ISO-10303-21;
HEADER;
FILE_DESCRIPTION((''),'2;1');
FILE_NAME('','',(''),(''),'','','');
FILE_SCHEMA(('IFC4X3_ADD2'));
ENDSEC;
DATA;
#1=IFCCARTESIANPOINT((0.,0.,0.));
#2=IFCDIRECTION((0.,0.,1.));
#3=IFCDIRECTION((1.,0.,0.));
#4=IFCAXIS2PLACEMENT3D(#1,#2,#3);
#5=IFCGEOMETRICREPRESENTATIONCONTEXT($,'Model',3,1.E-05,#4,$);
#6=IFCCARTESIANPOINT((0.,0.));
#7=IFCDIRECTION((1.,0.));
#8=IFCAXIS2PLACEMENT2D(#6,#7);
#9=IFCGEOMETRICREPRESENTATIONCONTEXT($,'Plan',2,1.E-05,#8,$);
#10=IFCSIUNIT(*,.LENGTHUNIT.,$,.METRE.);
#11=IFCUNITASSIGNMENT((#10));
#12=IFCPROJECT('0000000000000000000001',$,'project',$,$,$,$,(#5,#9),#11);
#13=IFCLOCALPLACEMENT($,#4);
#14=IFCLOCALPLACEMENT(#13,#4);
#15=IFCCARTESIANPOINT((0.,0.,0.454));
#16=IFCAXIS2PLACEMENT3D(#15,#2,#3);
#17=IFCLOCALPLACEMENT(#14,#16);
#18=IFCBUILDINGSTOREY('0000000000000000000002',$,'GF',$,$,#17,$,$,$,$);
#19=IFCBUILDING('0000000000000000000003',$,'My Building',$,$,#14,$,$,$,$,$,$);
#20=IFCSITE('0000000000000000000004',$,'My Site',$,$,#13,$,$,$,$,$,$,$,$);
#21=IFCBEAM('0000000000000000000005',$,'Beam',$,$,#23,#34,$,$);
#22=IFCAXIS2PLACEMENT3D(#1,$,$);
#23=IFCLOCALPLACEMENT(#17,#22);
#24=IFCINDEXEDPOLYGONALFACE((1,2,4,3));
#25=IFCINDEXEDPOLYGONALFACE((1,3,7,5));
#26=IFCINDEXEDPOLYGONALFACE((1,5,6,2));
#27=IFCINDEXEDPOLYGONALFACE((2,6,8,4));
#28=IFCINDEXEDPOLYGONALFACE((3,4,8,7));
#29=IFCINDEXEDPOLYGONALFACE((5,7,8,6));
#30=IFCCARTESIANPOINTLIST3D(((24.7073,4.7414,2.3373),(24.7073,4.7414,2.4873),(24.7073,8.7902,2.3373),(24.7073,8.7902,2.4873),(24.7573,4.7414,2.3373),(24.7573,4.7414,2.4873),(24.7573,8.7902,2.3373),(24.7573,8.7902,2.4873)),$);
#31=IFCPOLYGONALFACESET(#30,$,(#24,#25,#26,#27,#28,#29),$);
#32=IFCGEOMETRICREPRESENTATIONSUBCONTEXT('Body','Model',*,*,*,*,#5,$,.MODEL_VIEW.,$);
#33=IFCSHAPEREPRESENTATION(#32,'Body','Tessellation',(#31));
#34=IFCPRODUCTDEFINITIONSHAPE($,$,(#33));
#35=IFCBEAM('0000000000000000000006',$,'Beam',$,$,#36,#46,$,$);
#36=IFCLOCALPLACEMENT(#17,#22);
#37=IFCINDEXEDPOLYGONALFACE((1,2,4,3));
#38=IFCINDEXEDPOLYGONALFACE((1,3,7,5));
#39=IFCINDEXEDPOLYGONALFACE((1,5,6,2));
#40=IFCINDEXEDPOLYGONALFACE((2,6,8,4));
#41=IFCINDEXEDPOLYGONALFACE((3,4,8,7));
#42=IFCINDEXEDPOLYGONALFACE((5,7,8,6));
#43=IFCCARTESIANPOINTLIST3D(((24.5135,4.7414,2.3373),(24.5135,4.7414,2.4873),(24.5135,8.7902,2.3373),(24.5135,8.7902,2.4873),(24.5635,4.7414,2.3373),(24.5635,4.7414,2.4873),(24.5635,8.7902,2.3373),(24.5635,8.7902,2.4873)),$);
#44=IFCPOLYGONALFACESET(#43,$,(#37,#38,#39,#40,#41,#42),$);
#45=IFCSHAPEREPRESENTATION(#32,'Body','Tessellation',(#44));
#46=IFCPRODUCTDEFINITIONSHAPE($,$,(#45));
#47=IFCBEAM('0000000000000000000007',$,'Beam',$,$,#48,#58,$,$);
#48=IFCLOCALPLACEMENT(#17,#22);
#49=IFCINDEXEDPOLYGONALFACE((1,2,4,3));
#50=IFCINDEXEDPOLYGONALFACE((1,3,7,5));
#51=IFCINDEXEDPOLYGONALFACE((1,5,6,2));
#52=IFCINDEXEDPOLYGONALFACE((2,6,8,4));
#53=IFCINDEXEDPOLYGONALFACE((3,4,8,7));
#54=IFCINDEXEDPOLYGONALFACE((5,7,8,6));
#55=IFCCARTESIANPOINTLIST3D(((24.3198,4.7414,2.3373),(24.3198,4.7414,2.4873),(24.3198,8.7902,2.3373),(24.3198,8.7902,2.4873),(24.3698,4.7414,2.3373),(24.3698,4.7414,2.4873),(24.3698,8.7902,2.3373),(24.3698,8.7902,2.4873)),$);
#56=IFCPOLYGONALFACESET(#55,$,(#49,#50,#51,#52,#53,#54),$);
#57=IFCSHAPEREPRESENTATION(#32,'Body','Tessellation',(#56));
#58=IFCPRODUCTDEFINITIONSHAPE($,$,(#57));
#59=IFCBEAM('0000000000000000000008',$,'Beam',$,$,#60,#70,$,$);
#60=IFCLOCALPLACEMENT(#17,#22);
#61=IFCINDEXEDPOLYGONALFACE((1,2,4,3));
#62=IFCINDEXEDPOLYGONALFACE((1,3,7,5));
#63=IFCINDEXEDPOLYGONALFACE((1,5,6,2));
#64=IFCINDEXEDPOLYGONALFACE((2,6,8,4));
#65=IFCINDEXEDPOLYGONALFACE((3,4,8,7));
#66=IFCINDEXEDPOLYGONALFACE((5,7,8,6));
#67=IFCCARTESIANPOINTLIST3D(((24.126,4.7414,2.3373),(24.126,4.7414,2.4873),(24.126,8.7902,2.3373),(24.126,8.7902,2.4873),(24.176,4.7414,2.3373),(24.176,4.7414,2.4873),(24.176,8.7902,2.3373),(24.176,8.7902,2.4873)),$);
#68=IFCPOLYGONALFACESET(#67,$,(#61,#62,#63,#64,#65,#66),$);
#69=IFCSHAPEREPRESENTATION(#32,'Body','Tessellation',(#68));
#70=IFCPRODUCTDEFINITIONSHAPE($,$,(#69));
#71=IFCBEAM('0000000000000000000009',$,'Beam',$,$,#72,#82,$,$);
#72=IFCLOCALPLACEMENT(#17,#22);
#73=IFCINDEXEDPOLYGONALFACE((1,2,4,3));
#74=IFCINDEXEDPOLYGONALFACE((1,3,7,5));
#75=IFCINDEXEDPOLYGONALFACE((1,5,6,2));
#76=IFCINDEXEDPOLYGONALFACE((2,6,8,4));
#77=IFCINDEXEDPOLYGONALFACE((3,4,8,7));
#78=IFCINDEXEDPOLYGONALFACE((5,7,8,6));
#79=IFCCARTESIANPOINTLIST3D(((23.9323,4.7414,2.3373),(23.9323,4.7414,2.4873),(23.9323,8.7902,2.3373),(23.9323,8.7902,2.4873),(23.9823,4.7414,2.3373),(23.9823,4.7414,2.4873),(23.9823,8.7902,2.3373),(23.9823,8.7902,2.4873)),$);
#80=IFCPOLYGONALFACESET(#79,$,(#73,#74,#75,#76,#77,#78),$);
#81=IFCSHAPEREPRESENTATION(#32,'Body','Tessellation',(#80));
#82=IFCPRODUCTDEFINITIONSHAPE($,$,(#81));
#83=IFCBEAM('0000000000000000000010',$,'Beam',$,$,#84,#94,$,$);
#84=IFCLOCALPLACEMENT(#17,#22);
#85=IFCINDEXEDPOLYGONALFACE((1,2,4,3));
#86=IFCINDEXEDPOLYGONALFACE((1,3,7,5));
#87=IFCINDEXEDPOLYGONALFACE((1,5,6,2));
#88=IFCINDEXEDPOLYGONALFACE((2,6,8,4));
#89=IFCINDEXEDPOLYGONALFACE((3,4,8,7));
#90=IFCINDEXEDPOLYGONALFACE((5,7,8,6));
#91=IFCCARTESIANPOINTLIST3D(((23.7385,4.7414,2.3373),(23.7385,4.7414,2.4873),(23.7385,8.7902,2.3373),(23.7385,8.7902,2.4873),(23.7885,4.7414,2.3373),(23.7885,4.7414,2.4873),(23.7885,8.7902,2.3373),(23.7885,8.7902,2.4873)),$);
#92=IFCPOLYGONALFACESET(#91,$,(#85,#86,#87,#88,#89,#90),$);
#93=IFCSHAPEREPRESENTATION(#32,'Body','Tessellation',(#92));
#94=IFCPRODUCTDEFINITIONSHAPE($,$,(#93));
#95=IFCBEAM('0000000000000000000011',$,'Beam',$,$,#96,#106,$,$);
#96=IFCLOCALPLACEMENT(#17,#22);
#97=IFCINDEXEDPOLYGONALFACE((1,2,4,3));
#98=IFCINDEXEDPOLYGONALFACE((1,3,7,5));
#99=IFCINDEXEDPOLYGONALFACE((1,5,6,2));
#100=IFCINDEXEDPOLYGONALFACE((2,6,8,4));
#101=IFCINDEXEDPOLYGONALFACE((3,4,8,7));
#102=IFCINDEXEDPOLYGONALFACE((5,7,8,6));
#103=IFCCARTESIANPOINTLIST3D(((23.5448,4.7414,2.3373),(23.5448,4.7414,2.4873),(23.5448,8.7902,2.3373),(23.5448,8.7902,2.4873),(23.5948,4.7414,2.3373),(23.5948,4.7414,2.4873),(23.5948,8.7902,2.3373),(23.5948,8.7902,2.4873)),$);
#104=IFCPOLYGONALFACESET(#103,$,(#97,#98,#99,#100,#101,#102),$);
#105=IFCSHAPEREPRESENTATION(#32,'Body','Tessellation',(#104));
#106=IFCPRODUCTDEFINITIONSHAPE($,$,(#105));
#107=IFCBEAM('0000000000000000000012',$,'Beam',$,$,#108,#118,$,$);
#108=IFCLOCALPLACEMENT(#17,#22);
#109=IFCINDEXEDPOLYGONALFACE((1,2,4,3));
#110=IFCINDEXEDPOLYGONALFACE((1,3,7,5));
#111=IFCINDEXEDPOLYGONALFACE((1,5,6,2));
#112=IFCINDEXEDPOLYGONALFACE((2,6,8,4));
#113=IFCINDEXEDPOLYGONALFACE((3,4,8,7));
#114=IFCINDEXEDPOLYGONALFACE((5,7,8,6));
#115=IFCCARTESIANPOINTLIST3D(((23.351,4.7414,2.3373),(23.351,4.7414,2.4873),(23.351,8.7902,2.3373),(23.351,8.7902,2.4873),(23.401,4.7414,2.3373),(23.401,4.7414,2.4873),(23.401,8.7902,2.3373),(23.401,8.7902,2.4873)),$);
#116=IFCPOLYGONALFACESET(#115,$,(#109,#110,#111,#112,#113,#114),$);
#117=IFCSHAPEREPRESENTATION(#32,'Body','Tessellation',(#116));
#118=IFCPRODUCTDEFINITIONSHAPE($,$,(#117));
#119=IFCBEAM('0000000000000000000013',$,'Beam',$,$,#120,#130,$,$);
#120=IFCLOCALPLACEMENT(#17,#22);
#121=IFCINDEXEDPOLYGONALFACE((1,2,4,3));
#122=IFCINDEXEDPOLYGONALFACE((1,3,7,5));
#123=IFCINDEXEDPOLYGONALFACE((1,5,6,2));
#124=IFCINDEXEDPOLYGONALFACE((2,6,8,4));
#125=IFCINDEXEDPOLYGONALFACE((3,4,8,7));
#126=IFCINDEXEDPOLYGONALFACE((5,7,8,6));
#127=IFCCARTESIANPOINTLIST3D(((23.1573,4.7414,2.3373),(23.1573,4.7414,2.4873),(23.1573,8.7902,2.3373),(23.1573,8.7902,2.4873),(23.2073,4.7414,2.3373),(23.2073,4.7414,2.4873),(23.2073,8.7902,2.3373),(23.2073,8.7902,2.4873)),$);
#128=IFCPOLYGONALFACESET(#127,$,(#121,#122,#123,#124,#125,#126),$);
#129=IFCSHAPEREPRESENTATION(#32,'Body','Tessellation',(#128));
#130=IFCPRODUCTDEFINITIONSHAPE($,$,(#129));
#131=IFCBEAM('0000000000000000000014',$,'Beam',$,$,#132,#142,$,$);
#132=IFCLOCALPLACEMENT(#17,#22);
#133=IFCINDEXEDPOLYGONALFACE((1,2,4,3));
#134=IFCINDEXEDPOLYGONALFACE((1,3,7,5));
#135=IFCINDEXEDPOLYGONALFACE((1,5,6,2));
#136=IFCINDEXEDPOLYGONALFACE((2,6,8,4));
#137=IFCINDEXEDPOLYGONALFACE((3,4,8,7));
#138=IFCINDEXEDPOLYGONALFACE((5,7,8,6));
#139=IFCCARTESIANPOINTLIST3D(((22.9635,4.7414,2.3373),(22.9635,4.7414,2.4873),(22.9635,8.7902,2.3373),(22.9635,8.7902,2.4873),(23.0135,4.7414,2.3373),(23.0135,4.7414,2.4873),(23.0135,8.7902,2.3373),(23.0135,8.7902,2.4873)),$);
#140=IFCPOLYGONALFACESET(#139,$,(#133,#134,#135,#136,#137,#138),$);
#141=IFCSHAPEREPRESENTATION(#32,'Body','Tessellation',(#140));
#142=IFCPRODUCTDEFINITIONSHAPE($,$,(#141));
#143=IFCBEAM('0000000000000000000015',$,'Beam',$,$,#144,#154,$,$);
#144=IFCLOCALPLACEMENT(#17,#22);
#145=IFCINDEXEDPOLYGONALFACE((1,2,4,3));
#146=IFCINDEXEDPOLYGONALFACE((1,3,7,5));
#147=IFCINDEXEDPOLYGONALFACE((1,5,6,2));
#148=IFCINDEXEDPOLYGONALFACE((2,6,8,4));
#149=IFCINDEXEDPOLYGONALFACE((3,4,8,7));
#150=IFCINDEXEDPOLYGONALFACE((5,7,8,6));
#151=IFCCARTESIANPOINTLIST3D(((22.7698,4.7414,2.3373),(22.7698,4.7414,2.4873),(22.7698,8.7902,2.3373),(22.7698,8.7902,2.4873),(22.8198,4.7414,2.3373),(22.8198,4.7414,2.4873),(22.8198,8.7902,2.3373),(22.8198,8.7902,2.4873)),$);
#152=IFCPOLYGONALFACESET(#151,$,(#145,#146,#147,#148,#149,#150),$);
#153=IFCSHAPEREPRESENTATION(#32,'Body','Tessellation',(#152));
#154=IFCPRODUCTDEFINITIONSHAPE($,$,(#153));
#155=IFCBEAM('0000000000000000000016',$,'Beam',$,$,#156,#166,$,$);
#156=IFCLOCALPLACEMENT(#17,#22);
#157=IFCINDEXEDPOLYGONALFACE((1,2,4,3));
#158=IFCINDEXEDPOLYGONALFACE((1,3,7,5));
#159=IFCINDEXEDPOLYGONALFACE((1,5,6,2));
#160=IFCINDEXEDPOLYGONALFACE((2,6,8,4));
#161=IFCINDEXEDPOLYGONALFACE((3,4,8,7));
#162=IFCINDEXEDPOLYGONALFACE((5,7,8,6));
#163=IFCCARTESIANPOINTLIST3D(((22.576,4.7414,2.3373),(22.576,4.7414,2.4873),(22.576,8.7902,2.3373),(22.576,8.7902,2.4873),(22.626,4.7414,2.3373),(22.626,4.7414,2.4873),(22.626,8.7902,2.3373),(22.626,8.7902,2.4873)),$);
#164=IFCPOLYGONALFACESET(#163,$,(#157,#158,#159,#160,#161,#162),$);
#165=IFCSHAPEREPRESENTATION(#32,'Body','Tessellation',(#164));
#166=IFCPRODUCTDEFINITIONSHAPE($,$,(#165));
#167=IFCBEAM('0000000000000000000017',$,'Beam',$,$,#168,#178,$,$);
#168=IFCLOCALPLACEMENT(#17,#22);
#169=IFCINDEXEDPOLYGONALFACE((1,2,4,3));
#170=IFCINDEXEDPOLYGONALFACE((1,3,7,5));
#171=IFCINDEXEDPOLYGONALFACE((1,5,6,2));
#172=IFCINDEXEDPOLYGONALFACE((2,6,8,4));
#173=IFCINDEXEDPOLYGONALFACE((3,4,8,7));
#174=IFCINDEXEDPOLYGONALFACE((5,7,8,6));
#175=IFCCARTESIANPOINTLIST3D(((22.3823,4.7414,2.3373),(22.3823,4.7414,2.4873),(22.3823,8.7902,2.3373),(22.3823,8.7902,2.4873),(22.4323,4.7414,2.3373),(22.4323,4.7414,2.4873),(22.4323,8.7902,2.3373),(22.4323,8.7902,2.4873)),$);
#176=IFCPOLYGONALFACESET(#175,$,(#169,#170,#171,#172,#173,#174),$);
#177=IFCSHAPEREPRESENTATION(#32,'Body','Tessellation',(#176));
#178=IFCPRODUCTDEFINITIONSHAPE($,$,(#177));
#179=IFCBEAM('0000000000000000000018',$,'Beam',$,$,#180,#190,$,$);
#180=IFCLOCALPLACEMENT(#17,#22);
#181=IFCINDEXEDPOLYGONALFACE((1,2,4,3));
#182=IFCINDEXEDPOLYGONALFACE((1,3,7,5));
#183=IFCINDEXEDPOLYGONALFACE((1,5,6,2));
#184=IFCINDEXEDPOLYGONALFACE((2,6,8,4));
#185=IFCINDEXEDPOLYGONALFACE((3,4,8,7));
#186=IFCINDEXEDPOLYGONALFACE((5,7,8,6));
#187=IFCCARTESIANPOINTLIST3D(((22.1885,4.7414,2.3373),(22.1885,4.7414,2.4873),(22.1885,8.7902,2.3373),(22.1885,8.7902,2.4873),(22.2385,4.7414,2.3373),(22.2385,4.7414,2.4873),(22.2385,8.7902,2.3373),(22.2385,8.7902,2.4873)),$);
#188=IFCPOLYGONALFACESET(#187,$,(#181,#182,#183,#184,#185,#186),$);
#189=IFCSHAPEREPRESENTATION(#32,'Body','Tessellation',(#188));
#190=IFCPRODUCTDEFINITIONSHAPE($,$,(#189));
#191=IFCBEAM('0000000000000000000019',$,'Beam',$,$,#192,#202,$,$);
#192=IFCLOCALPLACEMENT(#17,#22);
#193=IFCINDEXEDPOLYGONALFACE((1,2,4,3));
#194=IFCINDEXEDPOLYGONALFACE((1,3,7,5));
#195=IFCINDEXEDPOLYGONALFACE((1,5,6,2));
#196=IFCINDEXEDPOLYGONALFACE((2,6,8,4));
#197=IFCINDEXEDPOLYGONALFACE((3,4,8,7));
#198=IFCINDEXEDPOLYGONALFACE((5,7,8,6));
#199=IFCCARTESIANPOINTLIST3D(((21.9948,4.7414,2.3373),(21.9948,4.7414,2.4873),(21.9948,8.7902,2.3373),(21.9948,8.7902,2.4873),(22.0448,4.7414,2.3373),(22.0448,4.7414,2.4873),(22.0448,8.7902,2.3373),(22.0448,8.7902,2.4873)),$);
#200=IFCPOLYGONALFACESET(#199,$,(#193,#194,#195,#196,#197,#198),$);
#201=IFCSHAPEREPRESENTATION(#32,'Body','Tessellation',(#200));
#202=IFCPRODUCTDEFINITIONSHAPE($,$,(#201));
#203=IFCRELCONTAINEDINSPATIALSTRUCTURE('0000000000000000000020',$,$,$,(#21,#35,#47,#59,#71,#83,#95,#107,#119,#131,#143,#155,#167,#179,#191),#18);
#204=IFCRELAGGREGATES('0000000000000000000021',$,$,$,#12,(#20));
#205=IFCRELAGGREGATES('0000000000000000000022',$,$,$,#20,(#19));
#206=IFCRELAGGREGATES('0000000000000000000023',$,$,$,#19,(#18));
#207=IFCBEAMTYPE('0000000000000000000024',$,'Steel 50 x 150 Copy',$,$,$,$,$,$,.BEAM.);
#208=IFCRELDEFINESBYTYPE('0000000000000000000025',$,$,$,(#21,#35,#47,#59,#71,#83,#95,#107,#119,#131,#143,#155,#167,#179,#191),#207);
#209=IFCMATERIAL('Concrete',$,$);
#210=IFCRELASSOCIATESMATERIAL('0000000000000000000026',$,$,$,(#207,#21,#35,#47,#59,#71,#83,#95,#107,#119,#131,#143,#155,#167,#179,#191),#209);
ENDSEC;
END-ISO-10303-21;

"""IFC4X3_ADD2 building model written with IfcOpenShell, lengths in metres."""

from ifc_helpers import new_model, si_unit, frame, origin_with_axes, origin_2d_with_axis, place, context, subcontext, project, spatial, rectangle, extrude, material, material_profile, profile_set, profile_usage, type_object, element, save


model = new_model("IFC4X3_ADD2")

# Units and contexts
model_context = context("Model", 3, precision=1e-05, world=origin_with_axes())
plan_context = context("Plan", 2, precision=1e-05, world=origin_2d_with_axis())
body_context = subcontext(model_context, "Body", "Model", "MODEL_VIEW")
ifc_project = project(units=[si_unit("LENGTHUNIT", "METRE")], contexts=[model_context, plan_context])

# Site, building, storey
site_placement = place(None, origin_with_axes())
site = spatial("IfcSite", under=ifc_project, at=site_placement, Name="My Site")
building_placement = place(site_placement, origin_with_axes())
building = spatial("IfcBuilding", under=site, at=building_placement, Name="My Building")
storey_placement = place(building_placement, frame((0.0, 0.0, 0.454), z_axis=(0.0, 0.0, 1.0), x_axis=(1.0, 0.0, 0.0)))
storey = spatial("IfcBuildingStorey", under=building, at=storey_placement, Name="GF")

# Beams
ifc_material_1 = material(Name="Concrete")
ifc_material_profile_1 = material_profile(ifc_material_1, rectangle(XDim=0.05, YDim=0.15))
ifc_profile_set_1 = profile_set([ifc_material_profile_1])
beam_type_1 = type_object("IfcBeamType", Name="Steel 50 x 150 Copy", PredefinedType="BEAM", material=ifc_profile_set_1)
ifc_profile_usage_1 = profile_usage(ifc_profile_set_1)
beam_1_placement = place(storey_placement, frame((24.7323, 8.7902, 2.4123), z_axis=(0.0, -1.0, 0.0), x_axis=(1.0, 0.0, 0.0)))
element("IfcBeam", 1, at=beam_1_placement, inside=storey, type_object=beam_type_1, material=ifc_profile_usage_1, Name="Beam", context=body_context, shape_type="SweptSolid", body=[
    extrude(rectangle(XDim=0.05, YDim=0.15), origin_with_axes(), (0.0, 0.0, 1.0), 4.0488),
])
ifc_profile_usage_2 = profile_usage(ifc_profile_set_1)
beam_2_placement = place(storey_placement, frame((24.5385, 8.7902, 2.4123), z_axis=(0.0, -1.0, 0.0), x_axis=(1.0, 0.0, 0.0)))
element("IfcBeam", 2, at=beam_2_placement, inside=storey, type_object=beam_type_1, material=ifc_profile_usage_2, Name="Beam", context=body_context, shape_type="SweptSolid", body=[
    extrude(rectangle(XDim=0.05, YDim=0.15), origin_with_axes(), (0.0, 0.0, 1.0), 4.0488),
])
ifc_profile_usage_3 = profile_usage(ifc_profile_set_1)
beam_3_placement = place(storey_placement, frame((24.3448, 8.7902, 2.4123), z_axis=(0.0, -1.0, 0.0), x_axis=(1.0, 0.0, 0.0)))
element("IfcBeam", 3, at=beam_3_placement, inside=storey, type_object=beam_type_1, material=ifc_profile_usage_3, Name="Beam", context=body_context, shape_type="SweptSolid", body=[
    extrude(rectangle(XDim=0.05, YDim=0.15), origin_with_axes(), (0.0, 0.0, 1.0), 4.0488),
])
ifc_profile_usage_4 = profile_usage(ifc_profile_set_1)
beam_4_placement = place(storey_placement, frame((24.151, 8.7902, 2.4123), z_axis=(0.0, -1.0, 0.0), x_axis=(1.0, 0.0, 0.0)))
element("IfcBeam", 4, at=beam_4_placement, inside=storey, type_object=beam_type_1, material=ifc_profile_usage_4, Name="Beam", context=body_context, shape_type="SweptSolid", body=[
    extrude(rectangle(XDim=0.05, YDim=0.15), origin_with_axes(), (0.0, 0.0, 1.0), 4.0488),
])
ifc_profile_usage_5 = profile_usage(ifc_profile_set_1)
beam_5_placement = place(storey_placement, frame((23.9573, 8.7902, 2.4123), z_axis=(0.0, -1.0, 0.0), x_axis=(1.0, 0.0, 0.0)))
element("IfcBeam", 5, at=beam_5_placement, inside=storey, type_object=beam_type_1, material=ifc_profile_usage_5, Name="Beam", context=body_context, shape_type="SweptSolid", body=[
    extrude(rectangle(XDim=0.05, YDim=0.15), origin_with_axes(), (0.0, 0.0, 1.0), 4.0488),
])
ifc_profile_usage_6 = profile_usage(ifc_profile_set_1)
beam_6_placement = place(storey_placement, frame((23.7635, 8.7902, 2.4123), z_axis=(0.0, -1.0, 0.0), x_axis=(1.0, 0.0, 0.0)))
element("IfcBeam", 6, at=beam_6_placement, inside=storey, type_object=beam_type_1, material=ifc_profile_usage_6, Name="Beam", context=body_context, shape_type="SweptSolid", body=[
    extrude(rectangle(XDim=0.05, YDim=0.15), origin_with_axes(), (0.0, 0.0, 1.0), 4.0488),
])
ifc_profile_usage_7 = profile_usage(ifc_profile_set_1)
beam_7_placement = place(storey_placement, frame((23.5698, 8.7902, 2.4123), z_axis=(0.0, -1.0, 0.0), x_axis=(1.0, 0.0, 0.0)))
element("IfcBeam", 7, at=beam_7_placement, inside=storey, type_object=beam_type_1, material=ifc_profile_usage_7, Name="Beam", context=body_context, shape_type="SweptSolid", body=[
    extrude(rectangle(XDim=0.05, YDim=0.15), origin_with_axes(), (0.0, 0.0, 1.0), 4.0488),
])
ifc_profile_usage_8 = profile_usage(ifc_profile_set_1)
beam_8_placement = place(storey_placement, frame((23.376, 8.7902, 2.4123), z_axis=(0.0, -1.0, 0.0), x_axis=(1.0, 0.0, 0.0)))
element("IfcBeam", 8, at=beam_8_placement, inside=storey, type_object=beam_type_1, material=ifc_profile_usage_8, Name="Beam", context=body_context, shape_type="SweptSolid", body=[
    extrude(rectangle(XDim=0.05, YDim=0.15), origin_with_axes(), (0.0, 0.0, 1.0), 4.0488),
])
ifc_profile_usage_9 = profile_usage(ifc_profile_set_1)
beam_9_placement = place(storey_placement, frame((23.1823, 8.7902, 2.4123), z_axis=(0.0, -1.0, 0.0), x_axis=(1.0, 0.0, 0.0)))
element("IfcBeam", 9, at=beam_9_placement, inside=storey, type_object=beam_type_1, material=ifc_profile_usage_9, Name="Beam", context=body_context, shape_type="SweptSolid", body=[
    extrude(rectangle(XDim=0.05, YDim=0.15), origin_with_axes(), (0.0, 0.0, 1.0), 4.0488),
])
ifc_profile_usage_10 = profile_usage(ifc_profile_set_1)
beam_10_placement = place(storey_placement, frame((22.9885, 8.7902, 2.4123), z_axis=(0.0, -1.0, 0.0), x_axis=(1.0, 0.0, 0.0)))
element("IfcBeam", 10, at=beam_10_placement, inside=storey, type_object=beam_type_1, material=ifc_profile_usage_10, Name="Beam", context=body_context, shape_type="SweptSolid", body=[
    extrude(rectangle(XDim=0.05, YDim=0.15), origin_with_axes(), (0.0, 0.0, 1.0), 4.0488),
])
ifc_profile_usage_11 = profile_usage(ifc_profile_set_1)
beam_11_placement = place(storey_placement, frame((22.7948, 8.7902, 2.4123), z_axis=(0.0, -1.0, 0.0), x_axis=(1.0, 0.0, 0.0)))
element("IfcBeam", 11, at=beam_11_placement, inside=storey, type_object=beam_type_1, material=ifc_profile_usage_11, Name="Beam", context=body_context, shape_type="SweptSolid", body=[
    extrude(rectangle(XDim=0.05, YDim=0.15), origin_with_axes(), (0.0, 0.0, 1.0), 4.0488),
])
ifc_profile_usage_12 = profile_usage(ifc_profile_set_1)
beam_12_placement = place(storey_placement, frame((22.601, 8.7902, 2.4123), z_axis=(0.0, -1.0, 0.0), x_axis=(1.0, 0.0, 0.0)))
element("IfcBeam", 12, at=beam_12_placement, inside=storey, type_object=beam_type_1, material=ifc_profile_usage_12, Name="Beam", context=body_context, shape_type="SweptSolid", body=[
    extrude(rectangle(XDim=0.05, YDim=0.15), origin_with_axes(), (0.0, 0.0, 1.0), 4.0488),
])
ifc_profile_usage_13 = profile_usage(ifc_profile_set_1)
beam_13_placement = place(storey_placement, frame((22.4073, 8.7902, 2.4123), z_axis=(0.0, -1.0, 0.0), x_axis=(1.0, 0.0, 0.0)))
element("IfcBeam", 13, at=beam_13_placement, inside=storey, type_object=beam_type_1, material=ifc_profile_usage_13, Name="Beam", context=body_context, shape_type="SweptSolid", body=[
    extrude(rectangle(XDim=0.05, YDim=0.15), origin_with_axes(), (0.0, 0.0, 1.0), 4.0488),
])
ifc_profile_usage_14 = profile_usage(ifc_profile_set_1)
beam_14_placement = place(storey_placement, frame((22.2135, 8.7902, 2.4123), z_axis=(0.0, -1.0, 0.0), x_axis=(1.0, 0.0, 0.0)))
element("IfcBeam", 14, at=beam_14_placement, inside=storey, type_object=beam_type_1, material=ifc_profile_usage_14, Name="Beam", context=body_context, shape_type="SweptSolid", body=[
    extrude(rectangle(XDim=0.05, YDim=0.15), origin_with_axes(), (0.0, 0.0, 1.0), 4.0488),
])
ifc_profile_usage_15 = profile_usage(ifc_profile_set_1)
beam_15_placement = place(storey_placement, frame((22.0198, 8.7902, 2.4123), z_axis=(0.0, -1.0, 0.0), x_axis=(1.0, 0.0, 0.0)))
element("IfcBeam", 15, at=beam_15_placement, inside=storey, type_object=beam_type_1, material=ifc_profile_usage_15, Name="Beam", context=body_context, shape_type="SweptSolid", body=[
    extrude(rectangle(XDim=0.05, YDim=0.15), origin_with_axes(), (0.0, 0.0, 1.0), 4.0488),
])

save(model, "model.ifc")
